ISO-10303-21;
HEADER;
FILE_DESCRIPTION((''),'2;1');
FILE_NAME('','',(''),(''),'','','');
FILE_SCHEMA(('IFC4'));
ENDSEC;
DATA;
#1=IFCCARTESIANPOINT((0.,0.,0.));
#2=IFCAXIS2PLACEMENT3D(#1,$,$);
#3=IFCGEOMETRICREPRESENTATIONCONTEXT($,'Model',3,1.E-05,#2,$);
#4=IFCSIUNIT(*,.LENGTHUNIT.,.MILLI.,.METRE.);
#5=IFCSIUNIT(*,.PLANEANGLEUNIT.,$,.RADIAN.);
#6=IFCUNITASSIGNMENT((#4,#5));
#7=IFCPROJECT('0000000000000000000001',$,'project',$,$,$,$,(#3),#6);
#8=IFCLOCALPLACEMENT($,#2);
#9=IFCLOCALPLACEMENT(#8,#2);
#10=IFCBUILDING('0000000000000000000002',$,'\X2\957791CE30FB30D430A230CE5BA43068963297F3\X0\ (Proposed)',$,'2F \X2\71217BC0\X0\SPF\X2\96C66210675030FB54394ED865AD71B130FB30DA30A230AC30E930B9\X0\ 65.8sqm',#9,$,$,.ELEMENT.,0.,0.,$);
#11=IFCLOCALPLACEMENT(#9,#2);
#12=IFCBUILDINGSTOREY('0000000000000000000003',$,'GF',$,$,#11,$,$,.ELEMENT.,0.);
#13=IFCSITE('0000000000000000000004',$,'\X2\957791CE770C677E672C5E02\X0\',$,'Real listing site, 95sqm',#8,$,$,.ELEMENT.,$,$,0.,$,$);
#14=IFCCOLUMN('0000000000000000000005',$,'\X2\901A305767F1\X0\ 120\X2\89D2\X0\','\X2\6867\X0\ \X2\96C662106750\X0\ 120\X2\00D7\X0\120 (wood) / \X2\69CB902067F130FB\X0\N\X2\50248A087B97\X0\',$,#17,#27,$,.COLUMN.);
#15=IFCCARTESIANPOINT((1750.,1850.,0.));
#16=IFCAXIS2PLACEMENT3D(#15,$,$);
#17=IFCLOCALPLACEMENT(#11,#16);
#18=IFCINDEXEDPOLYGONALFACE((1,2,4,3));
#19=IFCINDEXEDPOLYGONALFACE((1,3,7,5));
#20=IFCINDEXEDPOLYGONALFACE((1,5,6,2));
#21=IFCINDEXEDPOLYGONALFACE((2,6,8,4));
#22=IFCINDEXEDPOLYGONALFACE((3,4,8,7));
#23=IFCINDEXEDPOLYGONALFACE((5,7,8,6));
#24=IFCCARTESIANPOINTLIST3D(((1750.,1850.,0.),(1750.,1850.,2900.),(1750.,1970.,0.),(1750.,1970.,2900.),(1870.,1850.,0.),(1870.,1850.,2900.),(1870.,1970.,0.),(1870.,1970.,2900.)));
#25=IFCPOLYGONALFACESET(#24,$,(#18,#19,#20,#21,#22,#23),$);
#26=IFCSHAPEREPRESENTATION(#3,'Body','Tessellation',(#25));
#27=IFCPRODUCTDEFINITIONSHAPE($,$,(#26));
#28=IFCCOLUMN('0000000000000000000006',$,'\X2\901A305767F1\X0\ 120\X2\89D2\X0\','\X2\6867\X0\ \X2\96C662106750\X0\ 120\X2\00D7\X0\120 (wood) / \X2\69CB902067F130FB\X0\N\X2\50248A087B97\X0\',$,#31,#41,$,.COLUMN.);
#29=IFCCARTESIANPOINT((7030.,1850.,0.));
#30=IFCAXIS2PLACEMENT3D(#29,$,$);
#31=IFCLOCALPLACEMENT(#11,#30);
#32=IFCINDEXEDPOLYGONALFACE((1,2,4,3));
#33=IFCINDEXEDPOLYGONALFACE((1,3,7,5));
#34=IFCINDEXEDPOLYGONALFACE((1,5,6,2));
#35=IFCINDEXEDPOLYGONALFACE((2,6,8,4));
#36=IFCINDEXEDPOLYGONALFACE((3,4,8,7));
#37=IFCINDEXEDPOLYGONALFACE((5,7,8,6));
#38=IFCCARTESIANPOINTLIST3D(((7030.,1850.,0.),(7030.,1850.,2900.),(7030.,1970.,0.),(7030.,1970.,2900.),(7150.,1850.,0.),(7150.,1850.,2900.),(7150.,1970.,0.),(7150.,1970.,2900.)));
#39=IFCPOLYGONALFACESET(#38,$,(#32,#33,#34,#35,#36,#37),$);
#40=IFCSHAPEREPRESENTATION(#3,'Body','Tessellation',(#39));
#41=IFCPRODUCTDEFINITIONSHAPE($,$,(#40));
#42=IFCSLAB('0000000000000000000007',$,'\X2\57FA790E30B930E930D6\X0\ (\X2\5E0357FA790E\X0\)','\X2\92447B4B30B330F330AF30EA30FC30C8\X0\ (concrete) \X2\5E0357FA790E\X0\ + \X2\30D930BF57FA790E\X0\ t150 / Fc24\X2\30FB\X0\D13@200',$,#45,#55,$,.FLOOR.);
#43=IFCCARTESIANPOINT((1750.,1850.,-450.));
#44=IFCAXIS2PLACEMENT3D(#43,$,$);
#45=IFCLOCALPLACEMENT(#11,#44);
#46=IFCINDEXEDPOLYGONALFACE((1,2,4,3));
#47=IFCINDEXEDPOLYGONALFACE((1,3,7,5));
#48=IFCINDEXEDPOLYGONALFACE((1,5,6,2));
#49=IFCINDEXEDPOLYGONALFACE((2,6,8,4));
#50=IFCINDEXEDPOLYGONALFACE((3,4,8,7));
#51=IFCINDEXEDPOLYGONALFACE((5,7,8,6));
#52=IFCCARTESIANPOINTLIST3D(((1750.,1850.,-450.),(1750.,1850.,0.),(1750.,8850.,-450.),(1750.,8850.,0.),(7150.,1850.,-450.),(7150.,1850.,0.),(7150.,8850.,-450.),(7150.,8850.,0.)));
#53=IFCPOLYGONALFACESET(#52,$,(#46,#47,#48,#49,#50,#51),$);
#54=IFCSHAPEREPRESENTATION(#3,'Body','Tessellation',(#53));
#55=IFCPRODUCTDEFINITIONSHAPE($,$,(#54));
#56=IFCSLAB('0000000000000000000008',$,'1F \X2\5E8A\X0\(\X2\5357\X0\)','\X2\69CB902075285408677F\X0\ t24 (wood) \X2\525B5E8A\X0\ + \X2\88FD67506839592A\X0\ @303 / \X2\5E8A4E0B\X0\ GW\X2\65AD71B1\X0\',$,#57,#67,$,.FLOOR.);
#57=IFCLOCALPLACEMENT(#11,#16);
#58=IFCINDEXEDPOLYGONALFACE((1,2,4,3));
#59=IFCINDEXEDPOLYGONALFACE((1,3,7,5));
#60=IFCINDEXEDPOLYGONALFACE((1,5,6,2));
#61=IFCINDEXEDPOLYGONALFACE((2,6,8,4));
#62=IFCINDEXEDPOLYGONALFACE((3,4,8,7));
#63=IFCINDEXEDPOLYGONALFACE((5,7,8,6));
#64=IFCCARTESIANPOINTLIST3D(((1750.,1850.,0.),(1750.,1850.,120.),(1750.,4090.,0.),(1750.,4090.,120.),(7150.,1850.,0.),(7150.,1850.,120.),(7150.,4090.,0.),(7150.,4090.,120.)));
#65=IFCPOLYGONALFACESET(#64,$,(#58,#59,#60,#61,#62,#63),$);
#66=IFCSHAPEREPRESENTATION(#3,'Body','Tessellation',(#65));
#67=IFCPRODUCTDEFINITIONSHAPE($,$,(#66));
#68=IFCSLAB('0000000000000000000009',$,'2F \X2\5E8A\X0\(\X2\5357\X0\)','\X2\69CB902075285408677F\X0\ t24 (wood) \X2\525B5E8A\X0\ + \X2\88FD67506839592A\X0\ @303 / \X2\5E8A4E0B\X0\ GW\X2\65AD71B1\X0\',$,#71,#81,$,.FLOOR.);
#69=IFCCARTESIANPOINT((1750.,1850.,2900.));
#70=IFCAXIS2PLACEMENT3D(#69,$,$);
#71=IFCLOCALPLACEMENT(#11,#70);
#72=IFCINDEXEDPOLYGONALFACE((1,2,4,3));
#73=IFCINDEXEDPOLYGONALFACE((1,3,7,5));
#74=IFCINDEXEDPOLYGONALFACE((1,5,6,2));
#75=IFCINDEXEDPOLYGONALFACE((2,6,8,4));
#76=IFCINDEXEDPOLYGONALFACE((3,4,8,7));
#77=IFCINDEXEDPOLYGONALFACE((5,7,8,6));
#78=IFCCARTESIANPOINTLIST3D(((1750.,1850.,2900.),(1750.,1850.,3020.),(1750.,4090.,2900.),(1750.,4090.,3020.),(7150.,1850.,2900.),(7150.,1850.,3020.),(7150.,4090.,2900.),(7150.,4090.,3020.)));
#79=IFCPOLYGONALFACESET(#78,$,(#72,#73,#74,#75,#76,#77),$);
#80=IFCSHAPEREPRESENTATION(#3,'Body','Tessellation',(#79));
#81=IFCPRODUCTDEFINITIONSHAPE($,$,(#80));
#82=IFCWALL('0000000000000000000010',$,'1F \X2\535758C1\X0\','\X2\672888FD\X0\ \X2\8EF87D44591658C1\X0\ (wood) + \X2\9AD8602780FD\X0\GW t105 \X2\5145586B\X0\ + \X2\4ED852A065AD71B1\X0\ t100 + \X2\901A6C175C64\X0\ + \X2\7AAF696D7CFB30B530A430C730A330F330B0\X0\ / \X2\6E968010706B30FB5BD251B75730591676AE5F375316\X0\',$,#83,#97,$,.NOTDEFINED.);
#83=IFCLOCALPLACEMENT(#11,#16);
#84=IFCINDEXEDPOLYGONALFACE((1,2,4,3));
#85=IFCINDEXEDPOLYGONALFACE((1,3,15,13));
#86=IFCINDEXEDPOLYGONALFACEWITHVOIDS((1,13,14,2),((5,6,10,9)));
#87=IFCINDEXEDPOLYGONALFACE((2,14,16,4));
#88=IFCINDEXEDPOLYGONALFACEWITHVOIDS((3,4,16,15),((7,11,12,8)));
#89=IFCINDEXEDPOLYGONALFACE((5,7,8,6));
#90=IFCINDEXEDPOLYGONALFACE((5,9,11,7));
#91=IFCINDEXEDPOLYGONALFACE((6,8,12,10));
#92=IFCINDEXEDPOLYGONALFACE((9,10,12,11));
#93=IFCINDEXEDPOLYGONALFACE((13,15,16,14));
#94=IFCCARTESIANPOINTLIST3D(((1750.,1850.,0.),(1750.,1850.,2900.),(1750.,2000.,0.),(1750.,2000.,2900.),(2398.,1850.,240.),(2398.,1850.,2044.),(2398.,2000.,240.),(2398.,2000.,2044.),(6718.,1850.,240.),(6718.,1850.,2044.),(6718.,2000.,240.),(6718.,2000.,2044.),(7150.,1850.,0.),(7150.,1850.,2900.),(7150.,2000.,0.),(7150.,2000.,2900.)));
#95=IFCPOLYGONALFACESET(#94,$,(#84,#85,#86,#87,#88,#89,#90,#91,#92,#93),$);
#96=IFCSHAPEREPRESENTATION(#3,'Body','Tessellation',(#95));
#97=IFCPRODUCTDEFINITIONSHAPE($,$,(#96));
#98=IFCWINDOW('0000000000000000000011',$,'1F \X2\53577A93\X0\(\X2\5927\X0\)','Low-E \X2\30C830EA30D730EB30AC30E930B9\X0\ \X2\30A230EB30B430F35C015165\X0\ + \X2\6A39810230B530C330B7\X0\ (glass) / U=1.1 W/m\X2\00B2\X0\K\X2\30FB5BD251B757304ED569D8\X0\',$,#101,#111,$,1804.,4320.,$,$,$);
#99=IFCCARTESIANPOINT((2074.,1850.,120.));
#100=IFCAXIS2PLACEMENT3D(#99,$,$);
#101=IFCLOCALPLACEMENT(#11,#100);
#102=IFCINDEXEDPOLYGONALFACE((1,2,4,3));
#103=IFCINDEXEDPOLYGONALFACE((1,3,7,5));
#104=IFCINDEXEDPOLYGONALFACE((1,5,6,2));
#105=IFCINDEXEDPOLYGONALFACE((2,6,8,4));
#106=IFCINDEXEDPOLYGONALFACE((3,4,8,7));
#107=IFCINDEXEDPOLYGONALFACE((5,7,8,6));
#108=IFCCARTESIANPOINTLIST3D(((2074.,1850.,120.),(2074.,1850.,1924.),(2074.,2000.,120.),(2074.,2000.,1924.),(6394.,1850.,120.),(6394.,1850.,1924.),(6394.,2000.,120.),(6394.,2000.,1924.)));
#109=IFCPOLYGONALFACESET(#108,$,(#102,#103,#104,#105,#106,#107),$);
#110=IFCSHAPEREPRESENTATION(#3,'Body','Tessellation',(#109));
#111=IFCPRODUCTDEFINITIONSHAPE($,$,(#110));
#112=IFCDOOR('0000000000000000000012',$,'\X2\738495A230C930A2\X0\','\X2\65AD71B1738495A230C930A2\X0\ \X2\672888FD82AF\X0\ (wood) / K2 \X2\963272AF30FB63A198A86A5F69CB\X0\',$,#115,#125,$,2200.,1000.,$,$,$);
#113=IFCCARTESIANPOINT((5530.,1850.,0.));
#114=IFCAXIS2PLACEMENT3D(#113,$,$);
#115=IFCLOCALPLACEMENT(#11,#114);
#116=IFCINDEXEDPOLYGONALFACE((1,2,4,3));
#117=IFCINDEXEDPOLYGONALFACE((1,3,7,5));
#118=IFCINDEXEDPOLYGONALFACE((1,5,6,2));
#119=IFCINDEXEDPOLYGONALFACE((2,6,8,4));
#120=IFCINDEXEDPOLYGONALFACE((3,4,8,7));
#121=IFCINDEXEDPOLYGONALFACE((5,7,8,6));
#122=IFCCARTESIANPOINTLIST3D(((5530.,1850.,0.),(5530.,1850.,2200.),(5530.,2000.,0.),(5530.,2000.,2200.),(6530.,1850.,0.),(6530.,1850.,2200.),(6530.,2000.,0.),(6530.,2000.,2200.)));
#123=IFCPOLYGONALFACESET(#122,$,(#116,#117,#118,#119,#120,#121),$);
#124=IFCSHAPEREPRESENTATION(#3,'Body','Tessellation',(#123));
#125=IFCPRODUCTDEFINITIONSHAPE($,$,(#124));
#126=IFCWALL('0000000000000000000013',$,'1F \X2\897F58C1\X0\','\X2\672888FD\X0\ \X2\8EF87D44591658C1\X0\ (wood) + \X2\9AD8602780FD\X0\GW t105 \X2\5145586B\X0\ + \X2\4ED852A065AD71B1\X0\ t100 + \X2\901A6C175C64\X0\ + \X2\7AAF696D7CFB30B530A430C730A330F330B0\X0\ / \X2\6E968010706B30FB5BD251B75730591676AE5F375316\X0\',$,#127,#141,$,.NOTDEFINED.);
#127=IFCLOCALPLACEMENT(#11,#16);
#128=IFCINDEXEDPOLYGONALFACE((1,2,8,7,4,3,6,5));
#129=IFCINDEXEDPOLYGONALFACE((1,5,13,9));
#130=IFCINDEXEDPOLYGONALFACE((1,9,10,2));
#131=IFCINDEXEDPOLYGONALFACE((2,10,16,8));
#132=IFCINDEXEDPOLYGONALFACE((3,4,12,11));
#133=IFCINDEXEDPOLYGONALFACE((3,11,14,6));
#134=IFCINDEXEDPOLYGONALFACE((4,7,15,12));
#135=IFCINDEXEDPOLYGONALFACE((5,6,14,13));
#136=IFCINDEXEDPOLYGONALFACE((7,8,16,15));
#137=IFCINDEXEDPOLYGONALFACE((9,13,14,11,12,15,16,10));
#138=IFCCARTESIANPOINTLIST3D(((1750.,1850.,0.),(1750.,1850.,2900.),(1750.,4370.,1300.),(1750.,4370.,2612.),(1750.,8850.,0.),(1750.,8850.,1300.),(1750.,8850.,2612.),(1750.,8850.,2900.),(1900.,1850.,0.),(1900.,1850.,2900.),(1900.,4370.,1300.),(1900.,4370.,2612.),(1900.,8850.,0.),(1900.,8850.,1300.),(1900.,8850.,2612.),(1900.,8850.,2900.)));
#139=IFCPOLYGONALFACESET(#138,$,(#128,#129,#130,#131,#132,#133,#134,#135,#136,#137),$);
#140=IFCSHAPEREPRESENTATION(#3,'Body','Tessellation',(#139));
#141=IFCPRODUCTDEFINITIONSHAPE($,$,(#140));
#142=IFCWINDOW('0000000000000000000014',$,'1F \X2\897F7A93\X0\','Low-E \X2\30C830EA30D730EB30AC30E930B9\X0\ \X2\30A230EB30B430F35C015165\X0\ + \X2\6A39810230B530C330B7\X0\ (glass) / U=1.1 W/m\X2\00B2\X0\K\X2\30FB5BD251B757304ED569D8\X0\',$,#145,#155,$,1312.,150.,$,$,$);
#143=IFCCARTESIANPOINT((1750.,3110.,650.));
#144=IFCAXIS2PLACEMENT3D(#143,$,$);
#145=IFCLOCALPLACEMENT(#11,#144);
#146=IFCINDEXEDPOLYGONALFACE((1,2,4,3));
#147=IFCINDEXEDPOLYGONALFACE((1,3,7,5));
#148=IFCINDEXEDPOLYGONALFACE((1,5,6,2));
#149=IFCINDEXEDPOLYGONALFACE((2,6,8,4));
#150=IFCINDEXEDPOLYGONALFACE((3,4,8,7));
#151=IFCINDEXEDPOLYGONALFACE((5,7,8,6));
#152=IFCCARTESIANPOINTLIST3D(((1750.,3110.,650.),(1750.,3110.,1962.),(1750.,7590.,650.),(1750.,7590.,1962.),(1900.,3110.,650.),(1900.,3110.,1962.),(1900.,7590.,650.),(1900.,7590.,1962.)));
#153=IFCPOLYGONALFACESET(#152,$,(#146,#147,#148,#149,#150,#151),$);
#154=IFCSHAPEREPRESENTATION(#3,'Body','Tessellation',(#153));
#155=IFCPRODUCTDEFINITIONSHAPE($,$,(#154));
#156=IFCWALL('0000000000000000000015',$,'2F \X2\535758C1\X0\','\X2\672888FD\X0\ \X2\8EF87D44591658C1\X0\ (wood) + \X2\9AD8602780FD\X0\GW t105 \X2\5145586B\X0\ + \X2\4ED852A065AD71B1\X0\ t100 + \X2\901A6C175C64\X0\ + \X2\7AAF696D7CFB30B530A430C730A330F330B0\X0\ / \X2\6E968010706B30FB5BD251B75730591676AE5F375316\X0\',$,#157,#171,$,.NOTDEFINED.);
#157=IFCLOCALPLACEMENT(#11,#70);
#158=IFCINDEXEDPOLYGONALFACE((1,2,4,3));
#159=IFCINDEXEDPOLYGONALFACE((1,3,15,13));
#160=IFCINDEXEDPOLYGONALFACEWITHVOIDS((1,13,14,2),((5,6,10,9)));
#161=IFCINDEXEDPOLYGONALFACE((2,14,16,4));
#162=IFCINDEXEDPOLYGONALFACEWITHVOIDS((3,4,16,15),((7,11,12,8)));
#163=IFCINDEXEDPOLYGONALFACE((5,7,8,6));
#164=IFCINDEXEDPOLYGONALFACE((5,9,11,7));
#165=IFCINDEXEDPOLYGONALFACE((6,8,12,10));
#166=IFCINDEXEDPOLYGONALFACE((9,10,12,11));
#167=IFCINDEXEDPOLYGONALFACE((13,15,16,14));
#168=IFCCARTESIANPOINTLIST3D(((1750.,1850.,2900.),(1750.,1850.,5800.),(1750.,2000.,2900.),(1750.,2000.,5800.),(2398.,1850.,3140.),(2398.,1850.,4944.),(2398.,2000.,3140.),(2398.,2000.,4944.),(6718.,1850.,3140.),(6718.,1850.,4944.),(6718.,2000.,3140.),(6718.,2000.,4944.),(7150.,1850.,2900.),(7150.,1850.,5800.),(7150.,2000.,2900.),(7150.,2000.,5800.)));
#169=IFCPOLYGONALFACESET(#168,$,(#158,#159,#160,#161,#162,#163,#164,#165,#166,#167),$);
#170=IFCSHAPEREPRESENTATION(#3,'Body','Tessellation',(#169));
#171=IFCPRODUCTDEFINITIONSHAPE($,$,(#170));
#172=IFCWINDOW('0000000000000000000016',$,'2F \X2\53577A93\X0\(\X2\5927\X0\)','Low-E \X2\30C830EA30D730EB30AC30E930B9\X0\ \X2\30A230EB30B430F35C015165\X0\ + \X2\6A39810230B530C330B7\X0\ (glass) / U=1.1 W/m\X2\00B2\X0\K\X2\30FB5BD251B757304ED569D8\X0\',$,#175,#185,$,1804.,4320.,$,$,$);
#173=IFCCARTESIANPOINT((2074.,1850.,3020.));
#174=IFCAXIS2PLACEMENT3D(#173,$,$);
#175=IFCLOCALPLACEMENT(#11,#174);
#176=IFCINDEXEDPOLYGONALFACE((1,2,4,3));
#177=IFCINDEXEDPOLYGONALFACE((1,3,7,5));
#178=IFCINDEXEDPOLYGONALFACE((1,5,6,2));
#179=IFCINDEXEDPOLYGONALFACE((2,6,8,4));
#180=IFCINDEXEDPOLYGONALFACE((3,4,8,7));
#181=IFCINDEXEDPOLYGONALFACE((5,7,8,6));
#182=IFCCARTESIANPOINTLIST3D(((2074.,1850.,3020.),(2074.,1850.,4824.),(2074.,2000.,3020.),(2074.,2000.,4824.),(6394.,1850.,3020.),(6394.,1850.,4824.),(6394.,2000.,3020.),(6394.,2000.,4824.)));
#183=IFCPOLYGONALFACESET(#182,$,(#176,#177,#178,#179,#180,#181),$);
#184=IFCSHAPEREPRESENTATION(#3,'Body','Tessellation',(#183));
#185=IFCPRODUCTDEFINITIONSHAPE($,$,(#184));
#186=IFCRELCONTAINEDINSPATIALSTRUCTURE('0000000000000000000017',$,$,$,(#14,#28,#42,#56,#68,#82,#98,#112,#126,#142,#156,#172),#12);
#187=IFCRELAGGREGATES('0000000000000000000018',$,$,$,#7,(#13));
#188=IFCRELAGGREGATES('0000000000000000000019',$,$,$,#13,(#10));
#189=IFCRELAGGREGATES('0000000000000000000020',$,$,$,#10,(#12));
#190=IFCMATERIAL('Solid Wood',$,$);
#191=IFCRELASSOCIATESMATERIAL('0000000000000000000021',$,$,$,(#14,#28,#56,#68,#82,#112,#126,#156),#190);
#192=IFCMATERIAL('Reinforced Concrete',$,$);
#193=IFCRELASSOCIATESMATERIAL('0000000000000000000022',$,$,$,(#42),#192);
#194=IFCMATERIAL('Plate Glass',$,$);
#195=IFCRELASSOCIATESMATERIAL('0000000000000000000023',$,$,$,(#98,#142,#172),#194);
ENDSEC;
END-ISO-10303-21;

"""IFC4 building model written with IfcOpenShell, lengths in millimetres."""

from ifc_helpers import new_model, si_unit, frame, frame_2d, origin, place, context, project, spatial, rectangle, extrude, material, element, fill, save


model = new_model("IFC4")

# Units and contexts
model_context = context("Model", 3, precision=1e-05, world=origin())
ifc_project = project(units=[si_unit("LENGTHUNIT", "METRE", prefix="MILLI"), si_unit("PLANEANGLEUNIT", "RADIAN")], contexts=[model_context])

# Site, building, storey
site_placement = place(None, origin())
site = spatial("IfcSite", under=ifc_project, at=site_placement, Name="長野県松本市", ObjectType="Real listing site, 95sqm", CompositionType="ELEMENT", RefElevation=0.0)
building_placement = place(site_placement, origin())
building = spatial("IfcBuilding", under=site, at=building_placement, Name="長野・ピアノ室と防音 (Proposed)", ObjectType="2F 無節SPF集成材・吹付断熱・ペアガラス 65.8sqm", CompositionType="ELEMENT", ElevationOfRefHeight=0.0, ElevationOfTerrain=0.0)
storey_placement = place(building_placement, origin())
storey = spatial("IfcBuildingStorey", under=building, at=storey_placement, Name="GF", CompositionType="ELEMENT", Elevation=0.0)

# Columns
ifc_material_1 = material(Name="Solid Wood")
column_1_placement = place(storey_placement, frame((1750.0, 1850.0, 0.0)))
element("IfcColumn", 1, at=column_1_placement, inside=storey, material=ifc_material_1, Name="通し柱 120角", Description="桧 集成材 120×120 (wood) / 構造柱・N値計算", PredefinedType="COLUMN", context=model_context, shape_type="SweptSolid", body=[
    extrude(rectangle(XDim=120.0, YDim=120.0, at=frame_2d((60.0, 60.0))), frame((1750.0, 1850.0, 0.0)), (0.0, 0.0, 1.0), 2900.0),
])
column_2_placement = place(storey_placement, frame((7030.0, 1850.0, 0.0)))
element("IfcColumn", 2, at=column_2_placement, inside=storey, material=ifc_material_1, Name="通し柱 120角", Description="桧 集成材 120×120 (wood) / 構造柱・N値計算", PredefinedType="COLUMN", context=model_context, shape_type="SweptSolid", body=[
    extrude(rectangle(XDim=120.0, YDim=120.0, at=frame_2d((60.0, 60.0))), frame((7030.0, 1850.0, 0.0)), (0.0, 0.0, 1.0), 2900.0),
])

# Slabs
ifc_material_2 = material(Name="Reinforced Concrete")
slab_1_placement = place(storey_placement, frame((1750.0, 1850.0, -450.0)))
element("IfcSlab", 3, at=slab_1_placement, inside=storey, material=ifc_material_2, Name="基礎スラブ (布基礎)", Description="鉄筋コンクリート (concrete) 布基礎 + ベタ基礎 t150 / Fc24・D13@200", PredefinedType="FLOOR", context=model_context, shape_type="SweptSolid", body=[
    extrude(rectangle(XDim=5400.0, YDim=7000.0, at=frame_2d((2700.0, 3500.0))), frame((1750.0, 1850.0, -450.0)), (0.0, 0.0, 1.0), 450.0),
])
slab_2_placement = place(storey_placement, frame((1750.0, 1850.0, 0.0)))
element("IfcSlab", 4, at=slab_2_placement, inside=storey, material=ifc_material_1, Name="1F 床(南)", Description="構造用合板 t24 (wood) 剛床 + 製材根太 @303 / 床下 GW断熱", PredefinedType="FLOOR", context=model_context, shape_type="SweptSolid", body=[
    extrude(rectangle(XDim=5400.0, YDim=2240.0, at=frame_2d((2700.0, 1120.0))), frame((1750.0, 1850.0, 0.0)), (0.0, 0.0, 1.0), 120.0),
])
slab_3_placement = place(storey_placement, frame((1750.0, 1850.0, 2900.0)))
element("IfcSlab", 5, at=slab_3_placement, inside=storey, material=ifc_material_1, Name="2F 床(南)", Description="構造用合板 t24 (wood) 剛床 + 製材根太 @303 / 床下 GW断熱", PredefinedType="FLOOR", context=model_context, shape_type="SweptSolid", body=[
    extrude(rectangle(XDim=5400.0, YDim=2240.0, at=frame_2d((2700.0, 1120.0))), frame((1750.0, 1850.0, 2900.0)), (0.0, 0.0, 1.0), 120.0),
])

# Wall, openings, window, door
wall_1_placement = place(storey_placement, frame((1750.0, 1850.0, 0.0)))
wall_1 = element("IfcWall", 6, at=wall_1_placement, inside=storey, material=ifc_material_1, Name="1F 南壁", Description="木製 軸組外壁 (wood) + 高性能GW t105 充填 + 付加断熱 t100 + 通気層 + 窯業系サイディング / 準耐火・寒冷地外皮強化", PredefinedType="NOTDEFINED", context=model_context, shape_type="SweptSolid", body=[
    extrude(rectangle(XDim=5400.0, YDim=150.0, at=frame_2d((2700.0, 75.0))), frame((1750.0, 1850.0, 0.0)), (0.0, 0.0, 1.0), 2900.0),
])
opening_1_placement = place(storey_placement, frame((2074.0, 1850.0, 120.0)))
opening_1 = element("IfcOpeningElement", 7, at=opening_1_placement, cuts=wall_1, PredefinedType="NOTDEFINED", context=model_context, shape_type="SweptSolid", body=[
    extrude(rectangle(XDim=4320.0, YDim=150.0, at=frame_2d((2160.0, 75.0))), frame((2074.0, 1850.0, 120.0)), (0.0, 0.0, 1.0), 1804.0),
])
opening_2_placement = place(storey_placement, frame((5530.0, 1850.0, 0.0)))
opening_2 = element("IfcOpeningElement", 8, at=opening_2_placement, cuts=wall_1, PredefinedType="NOTDEFINED", context=model_context, shape_type="SweptSolid", body=[
    extrude(rectangle(XDim=1000.0, YDim=150.0, at=frame_2d((500.0, 75.0))), frame((5530.0, 1850.0, 0.0)), (0.0, 0.0, 1.0), 2200.0),
])
ifc_material_3 = material(Name="Plate Glass")
window_1_placement = place(storey_placement, frame((2074.0, 1850.0, 120.0)))
window_1 = element("IfcWindow", 9, at=window_1_placement, inside=storey, material=ifc_material_3, Name="1F 南窓(大)", Description="Low-E トリプルガラス アルゴン封入 + 樹脂サッシ (glass) / U=1.1 W/m²K・寒冷地仕様", OverallHeight=1804.0, OverallWidth=4320.0, context=model_context, shape_type="SweptSolid", body=[
    extrude(rectangle(XDim=4320.0, YDim=150.0, at=frame_2d((2160.0, 75.0))), frame((2074.0, 1850.0, 120.0)), (0.0, 0.0, 1.0), 1804.0),
])
fill(opening_1, window_1)
door_placement = place(storey_placement, frame((5530.0, 1850.0, 0.0)))
door = element("IfcDoor", 10, at=door_placement, inside=storey, material=ifc_material_1, Name="玄関ドア", Description="断熱玄関ドア 木製芯 (wood) / K2 防犯・採風機構", OverallHeight=2200.0, OverallWidth=1000.0, context=model_context, shape_type="SweptSolid", body=[
    extrude(rectangle(XDim=1000.0, YDim=150.0, at=frame_2d((500.0, 75.0))), frame((5530.0, 1850.0, 0.0)), (0.0, 0.0, 1.0), 2200.0),
])
fill(opening_2, door)

# Walls, openings, windows
wall_2_placement = place(storey_placement, frame((1750.0, 1850.0, 0.0)))
wall_2 = element("IfcWall", 11, at=wall_2_placement, inside=storey, material=ifc_material_1, Name="1F 西壁", Description="木製 軸組外壁 (wood) + 高性能GW t105 充填 + 付加断熱 t100 + 通気層 + 窯業系サイディング / 準耐火・寒冷地外皮強化", PredefinedType="NOTDEFINED", context=model_context, shape_type="SweptSolid", body=[
    extrude(rectangle(XDim=150.0, YDim=7000.0, at=frame_2d((75.0, 3500.0))), frame((1750.0, 1850.0, 0.0)), (0.0, 0.0, 1.0), 2900.0),
])
opening_3_placement = place(storey_placement, frame((1750.0, 3110.0, 650.0)))
opening_3 = element("IfcOpeningElement", 12, at=opening_3_placement, cuts=wall_2, PredefinedType="NOTDEFINED", context=model_context, shape_type="SweptSolid", body=[
    extrude(rectangle(XDim=150.0, YDim=4480.0, at=frame_2d((75.0, 2240.0))), frame((1750.0, 3110.0, 650.0)), (0.0, 0.0, 1.0), 1312.0),
])
window_2_placement = place(storey_placement, frame((1750.0, 3110.0, 650.0)))
window_2 = element("IfcWindow", 13, at=window_2_placement, inside=storey, material=ifc_material_3, Name="1F 西窓", Description="Low-E トリプルガラス アルゴン封入 + 樹脂サッシ (glass) / U=1.1 W/m²K・寒冷地仕様", OverallHeight=1312.0, OverallWidth=150.0, context=model_context, shape_type="SweptSolid", body=[
    extrude(rectangle(XDim=150.0, YDim=4480.0, at=frame_2d((75.0, 2240.0))), frame((1750.0, 3110.0, 650.0)), (0.0, 0.0, 1.0), 1312.0),
])
fill(opening_3, window_2)
wall_3_placement = place(storey_placement, frame((1750.0, 1850.0, 2900.0)))
wall_3 = element("IfcWall", 14, at=wall_3_placement, inside=storey, material=ifc_material_1, Name="2F 南壁", Description="木製 軸組外壁 (wood) + 高性能GW t105 充填 + 付加断熱 t100 + 通気層 + 窯業系サイディング / 準耐火・寒冷地外皮強化", PredefinedType="NOTDEFINED", context=model_context, shape_type="SweptSolid", body=[
    extrude(rectangle(XDim=5400.0, YDim=150.0, at=frame_2d((2700.0, 75.0))), frame((1750.0, 1850.0, 2900.0)), (0.0, 0.0, 1.0), 2900.0),
])
opening_4_placement = place(storey_placement, frame((2074.0, 1850.0, 3020.0)))
opening_4 = element("IfcOpeningElement", 15, at=opening_4_placement, cuts=wall_3, PredefinedType="NOTDEFINED", context=model_context, shape_type="SweptSolid", body=[
    extrude(rectangle(XDim=4320.0, YDim=150.0, at=frame_2d((2160.0, 75.0))), frame((2074.0, 1850.0, 3020.0)), (0.0, 0.0, 1.0), 1804.0),
])
window_3_placement = place(storey_placement, frame((2074.0, 1850.0, 3020.0)))
window_3 = element("IfcWindow", 16, at=window_3_placement, inside=storey, material=ifc_material_3, Name="2F 南窓(大)", Description="Low-E トリプルガラス アルゴン封入 + 樹脂サッシ (glass) / U=1.1 W/m²K・寒冷地仕様", OverallHeight=1804.0, OverallWidth=4320.0, context=model_context, shape_type="SweptSolid", body=[
    extrude(rectangle(XDim=4320.0, YDim=150.0, at=frame_2d((2160.0, 75.0))), frame((2074.0, 1850.0, 3020.0)), (0.0, 0.0, 1.0), 1804.0),
])
fill(opening_4, window_3)

save(model, "model.ifc")
